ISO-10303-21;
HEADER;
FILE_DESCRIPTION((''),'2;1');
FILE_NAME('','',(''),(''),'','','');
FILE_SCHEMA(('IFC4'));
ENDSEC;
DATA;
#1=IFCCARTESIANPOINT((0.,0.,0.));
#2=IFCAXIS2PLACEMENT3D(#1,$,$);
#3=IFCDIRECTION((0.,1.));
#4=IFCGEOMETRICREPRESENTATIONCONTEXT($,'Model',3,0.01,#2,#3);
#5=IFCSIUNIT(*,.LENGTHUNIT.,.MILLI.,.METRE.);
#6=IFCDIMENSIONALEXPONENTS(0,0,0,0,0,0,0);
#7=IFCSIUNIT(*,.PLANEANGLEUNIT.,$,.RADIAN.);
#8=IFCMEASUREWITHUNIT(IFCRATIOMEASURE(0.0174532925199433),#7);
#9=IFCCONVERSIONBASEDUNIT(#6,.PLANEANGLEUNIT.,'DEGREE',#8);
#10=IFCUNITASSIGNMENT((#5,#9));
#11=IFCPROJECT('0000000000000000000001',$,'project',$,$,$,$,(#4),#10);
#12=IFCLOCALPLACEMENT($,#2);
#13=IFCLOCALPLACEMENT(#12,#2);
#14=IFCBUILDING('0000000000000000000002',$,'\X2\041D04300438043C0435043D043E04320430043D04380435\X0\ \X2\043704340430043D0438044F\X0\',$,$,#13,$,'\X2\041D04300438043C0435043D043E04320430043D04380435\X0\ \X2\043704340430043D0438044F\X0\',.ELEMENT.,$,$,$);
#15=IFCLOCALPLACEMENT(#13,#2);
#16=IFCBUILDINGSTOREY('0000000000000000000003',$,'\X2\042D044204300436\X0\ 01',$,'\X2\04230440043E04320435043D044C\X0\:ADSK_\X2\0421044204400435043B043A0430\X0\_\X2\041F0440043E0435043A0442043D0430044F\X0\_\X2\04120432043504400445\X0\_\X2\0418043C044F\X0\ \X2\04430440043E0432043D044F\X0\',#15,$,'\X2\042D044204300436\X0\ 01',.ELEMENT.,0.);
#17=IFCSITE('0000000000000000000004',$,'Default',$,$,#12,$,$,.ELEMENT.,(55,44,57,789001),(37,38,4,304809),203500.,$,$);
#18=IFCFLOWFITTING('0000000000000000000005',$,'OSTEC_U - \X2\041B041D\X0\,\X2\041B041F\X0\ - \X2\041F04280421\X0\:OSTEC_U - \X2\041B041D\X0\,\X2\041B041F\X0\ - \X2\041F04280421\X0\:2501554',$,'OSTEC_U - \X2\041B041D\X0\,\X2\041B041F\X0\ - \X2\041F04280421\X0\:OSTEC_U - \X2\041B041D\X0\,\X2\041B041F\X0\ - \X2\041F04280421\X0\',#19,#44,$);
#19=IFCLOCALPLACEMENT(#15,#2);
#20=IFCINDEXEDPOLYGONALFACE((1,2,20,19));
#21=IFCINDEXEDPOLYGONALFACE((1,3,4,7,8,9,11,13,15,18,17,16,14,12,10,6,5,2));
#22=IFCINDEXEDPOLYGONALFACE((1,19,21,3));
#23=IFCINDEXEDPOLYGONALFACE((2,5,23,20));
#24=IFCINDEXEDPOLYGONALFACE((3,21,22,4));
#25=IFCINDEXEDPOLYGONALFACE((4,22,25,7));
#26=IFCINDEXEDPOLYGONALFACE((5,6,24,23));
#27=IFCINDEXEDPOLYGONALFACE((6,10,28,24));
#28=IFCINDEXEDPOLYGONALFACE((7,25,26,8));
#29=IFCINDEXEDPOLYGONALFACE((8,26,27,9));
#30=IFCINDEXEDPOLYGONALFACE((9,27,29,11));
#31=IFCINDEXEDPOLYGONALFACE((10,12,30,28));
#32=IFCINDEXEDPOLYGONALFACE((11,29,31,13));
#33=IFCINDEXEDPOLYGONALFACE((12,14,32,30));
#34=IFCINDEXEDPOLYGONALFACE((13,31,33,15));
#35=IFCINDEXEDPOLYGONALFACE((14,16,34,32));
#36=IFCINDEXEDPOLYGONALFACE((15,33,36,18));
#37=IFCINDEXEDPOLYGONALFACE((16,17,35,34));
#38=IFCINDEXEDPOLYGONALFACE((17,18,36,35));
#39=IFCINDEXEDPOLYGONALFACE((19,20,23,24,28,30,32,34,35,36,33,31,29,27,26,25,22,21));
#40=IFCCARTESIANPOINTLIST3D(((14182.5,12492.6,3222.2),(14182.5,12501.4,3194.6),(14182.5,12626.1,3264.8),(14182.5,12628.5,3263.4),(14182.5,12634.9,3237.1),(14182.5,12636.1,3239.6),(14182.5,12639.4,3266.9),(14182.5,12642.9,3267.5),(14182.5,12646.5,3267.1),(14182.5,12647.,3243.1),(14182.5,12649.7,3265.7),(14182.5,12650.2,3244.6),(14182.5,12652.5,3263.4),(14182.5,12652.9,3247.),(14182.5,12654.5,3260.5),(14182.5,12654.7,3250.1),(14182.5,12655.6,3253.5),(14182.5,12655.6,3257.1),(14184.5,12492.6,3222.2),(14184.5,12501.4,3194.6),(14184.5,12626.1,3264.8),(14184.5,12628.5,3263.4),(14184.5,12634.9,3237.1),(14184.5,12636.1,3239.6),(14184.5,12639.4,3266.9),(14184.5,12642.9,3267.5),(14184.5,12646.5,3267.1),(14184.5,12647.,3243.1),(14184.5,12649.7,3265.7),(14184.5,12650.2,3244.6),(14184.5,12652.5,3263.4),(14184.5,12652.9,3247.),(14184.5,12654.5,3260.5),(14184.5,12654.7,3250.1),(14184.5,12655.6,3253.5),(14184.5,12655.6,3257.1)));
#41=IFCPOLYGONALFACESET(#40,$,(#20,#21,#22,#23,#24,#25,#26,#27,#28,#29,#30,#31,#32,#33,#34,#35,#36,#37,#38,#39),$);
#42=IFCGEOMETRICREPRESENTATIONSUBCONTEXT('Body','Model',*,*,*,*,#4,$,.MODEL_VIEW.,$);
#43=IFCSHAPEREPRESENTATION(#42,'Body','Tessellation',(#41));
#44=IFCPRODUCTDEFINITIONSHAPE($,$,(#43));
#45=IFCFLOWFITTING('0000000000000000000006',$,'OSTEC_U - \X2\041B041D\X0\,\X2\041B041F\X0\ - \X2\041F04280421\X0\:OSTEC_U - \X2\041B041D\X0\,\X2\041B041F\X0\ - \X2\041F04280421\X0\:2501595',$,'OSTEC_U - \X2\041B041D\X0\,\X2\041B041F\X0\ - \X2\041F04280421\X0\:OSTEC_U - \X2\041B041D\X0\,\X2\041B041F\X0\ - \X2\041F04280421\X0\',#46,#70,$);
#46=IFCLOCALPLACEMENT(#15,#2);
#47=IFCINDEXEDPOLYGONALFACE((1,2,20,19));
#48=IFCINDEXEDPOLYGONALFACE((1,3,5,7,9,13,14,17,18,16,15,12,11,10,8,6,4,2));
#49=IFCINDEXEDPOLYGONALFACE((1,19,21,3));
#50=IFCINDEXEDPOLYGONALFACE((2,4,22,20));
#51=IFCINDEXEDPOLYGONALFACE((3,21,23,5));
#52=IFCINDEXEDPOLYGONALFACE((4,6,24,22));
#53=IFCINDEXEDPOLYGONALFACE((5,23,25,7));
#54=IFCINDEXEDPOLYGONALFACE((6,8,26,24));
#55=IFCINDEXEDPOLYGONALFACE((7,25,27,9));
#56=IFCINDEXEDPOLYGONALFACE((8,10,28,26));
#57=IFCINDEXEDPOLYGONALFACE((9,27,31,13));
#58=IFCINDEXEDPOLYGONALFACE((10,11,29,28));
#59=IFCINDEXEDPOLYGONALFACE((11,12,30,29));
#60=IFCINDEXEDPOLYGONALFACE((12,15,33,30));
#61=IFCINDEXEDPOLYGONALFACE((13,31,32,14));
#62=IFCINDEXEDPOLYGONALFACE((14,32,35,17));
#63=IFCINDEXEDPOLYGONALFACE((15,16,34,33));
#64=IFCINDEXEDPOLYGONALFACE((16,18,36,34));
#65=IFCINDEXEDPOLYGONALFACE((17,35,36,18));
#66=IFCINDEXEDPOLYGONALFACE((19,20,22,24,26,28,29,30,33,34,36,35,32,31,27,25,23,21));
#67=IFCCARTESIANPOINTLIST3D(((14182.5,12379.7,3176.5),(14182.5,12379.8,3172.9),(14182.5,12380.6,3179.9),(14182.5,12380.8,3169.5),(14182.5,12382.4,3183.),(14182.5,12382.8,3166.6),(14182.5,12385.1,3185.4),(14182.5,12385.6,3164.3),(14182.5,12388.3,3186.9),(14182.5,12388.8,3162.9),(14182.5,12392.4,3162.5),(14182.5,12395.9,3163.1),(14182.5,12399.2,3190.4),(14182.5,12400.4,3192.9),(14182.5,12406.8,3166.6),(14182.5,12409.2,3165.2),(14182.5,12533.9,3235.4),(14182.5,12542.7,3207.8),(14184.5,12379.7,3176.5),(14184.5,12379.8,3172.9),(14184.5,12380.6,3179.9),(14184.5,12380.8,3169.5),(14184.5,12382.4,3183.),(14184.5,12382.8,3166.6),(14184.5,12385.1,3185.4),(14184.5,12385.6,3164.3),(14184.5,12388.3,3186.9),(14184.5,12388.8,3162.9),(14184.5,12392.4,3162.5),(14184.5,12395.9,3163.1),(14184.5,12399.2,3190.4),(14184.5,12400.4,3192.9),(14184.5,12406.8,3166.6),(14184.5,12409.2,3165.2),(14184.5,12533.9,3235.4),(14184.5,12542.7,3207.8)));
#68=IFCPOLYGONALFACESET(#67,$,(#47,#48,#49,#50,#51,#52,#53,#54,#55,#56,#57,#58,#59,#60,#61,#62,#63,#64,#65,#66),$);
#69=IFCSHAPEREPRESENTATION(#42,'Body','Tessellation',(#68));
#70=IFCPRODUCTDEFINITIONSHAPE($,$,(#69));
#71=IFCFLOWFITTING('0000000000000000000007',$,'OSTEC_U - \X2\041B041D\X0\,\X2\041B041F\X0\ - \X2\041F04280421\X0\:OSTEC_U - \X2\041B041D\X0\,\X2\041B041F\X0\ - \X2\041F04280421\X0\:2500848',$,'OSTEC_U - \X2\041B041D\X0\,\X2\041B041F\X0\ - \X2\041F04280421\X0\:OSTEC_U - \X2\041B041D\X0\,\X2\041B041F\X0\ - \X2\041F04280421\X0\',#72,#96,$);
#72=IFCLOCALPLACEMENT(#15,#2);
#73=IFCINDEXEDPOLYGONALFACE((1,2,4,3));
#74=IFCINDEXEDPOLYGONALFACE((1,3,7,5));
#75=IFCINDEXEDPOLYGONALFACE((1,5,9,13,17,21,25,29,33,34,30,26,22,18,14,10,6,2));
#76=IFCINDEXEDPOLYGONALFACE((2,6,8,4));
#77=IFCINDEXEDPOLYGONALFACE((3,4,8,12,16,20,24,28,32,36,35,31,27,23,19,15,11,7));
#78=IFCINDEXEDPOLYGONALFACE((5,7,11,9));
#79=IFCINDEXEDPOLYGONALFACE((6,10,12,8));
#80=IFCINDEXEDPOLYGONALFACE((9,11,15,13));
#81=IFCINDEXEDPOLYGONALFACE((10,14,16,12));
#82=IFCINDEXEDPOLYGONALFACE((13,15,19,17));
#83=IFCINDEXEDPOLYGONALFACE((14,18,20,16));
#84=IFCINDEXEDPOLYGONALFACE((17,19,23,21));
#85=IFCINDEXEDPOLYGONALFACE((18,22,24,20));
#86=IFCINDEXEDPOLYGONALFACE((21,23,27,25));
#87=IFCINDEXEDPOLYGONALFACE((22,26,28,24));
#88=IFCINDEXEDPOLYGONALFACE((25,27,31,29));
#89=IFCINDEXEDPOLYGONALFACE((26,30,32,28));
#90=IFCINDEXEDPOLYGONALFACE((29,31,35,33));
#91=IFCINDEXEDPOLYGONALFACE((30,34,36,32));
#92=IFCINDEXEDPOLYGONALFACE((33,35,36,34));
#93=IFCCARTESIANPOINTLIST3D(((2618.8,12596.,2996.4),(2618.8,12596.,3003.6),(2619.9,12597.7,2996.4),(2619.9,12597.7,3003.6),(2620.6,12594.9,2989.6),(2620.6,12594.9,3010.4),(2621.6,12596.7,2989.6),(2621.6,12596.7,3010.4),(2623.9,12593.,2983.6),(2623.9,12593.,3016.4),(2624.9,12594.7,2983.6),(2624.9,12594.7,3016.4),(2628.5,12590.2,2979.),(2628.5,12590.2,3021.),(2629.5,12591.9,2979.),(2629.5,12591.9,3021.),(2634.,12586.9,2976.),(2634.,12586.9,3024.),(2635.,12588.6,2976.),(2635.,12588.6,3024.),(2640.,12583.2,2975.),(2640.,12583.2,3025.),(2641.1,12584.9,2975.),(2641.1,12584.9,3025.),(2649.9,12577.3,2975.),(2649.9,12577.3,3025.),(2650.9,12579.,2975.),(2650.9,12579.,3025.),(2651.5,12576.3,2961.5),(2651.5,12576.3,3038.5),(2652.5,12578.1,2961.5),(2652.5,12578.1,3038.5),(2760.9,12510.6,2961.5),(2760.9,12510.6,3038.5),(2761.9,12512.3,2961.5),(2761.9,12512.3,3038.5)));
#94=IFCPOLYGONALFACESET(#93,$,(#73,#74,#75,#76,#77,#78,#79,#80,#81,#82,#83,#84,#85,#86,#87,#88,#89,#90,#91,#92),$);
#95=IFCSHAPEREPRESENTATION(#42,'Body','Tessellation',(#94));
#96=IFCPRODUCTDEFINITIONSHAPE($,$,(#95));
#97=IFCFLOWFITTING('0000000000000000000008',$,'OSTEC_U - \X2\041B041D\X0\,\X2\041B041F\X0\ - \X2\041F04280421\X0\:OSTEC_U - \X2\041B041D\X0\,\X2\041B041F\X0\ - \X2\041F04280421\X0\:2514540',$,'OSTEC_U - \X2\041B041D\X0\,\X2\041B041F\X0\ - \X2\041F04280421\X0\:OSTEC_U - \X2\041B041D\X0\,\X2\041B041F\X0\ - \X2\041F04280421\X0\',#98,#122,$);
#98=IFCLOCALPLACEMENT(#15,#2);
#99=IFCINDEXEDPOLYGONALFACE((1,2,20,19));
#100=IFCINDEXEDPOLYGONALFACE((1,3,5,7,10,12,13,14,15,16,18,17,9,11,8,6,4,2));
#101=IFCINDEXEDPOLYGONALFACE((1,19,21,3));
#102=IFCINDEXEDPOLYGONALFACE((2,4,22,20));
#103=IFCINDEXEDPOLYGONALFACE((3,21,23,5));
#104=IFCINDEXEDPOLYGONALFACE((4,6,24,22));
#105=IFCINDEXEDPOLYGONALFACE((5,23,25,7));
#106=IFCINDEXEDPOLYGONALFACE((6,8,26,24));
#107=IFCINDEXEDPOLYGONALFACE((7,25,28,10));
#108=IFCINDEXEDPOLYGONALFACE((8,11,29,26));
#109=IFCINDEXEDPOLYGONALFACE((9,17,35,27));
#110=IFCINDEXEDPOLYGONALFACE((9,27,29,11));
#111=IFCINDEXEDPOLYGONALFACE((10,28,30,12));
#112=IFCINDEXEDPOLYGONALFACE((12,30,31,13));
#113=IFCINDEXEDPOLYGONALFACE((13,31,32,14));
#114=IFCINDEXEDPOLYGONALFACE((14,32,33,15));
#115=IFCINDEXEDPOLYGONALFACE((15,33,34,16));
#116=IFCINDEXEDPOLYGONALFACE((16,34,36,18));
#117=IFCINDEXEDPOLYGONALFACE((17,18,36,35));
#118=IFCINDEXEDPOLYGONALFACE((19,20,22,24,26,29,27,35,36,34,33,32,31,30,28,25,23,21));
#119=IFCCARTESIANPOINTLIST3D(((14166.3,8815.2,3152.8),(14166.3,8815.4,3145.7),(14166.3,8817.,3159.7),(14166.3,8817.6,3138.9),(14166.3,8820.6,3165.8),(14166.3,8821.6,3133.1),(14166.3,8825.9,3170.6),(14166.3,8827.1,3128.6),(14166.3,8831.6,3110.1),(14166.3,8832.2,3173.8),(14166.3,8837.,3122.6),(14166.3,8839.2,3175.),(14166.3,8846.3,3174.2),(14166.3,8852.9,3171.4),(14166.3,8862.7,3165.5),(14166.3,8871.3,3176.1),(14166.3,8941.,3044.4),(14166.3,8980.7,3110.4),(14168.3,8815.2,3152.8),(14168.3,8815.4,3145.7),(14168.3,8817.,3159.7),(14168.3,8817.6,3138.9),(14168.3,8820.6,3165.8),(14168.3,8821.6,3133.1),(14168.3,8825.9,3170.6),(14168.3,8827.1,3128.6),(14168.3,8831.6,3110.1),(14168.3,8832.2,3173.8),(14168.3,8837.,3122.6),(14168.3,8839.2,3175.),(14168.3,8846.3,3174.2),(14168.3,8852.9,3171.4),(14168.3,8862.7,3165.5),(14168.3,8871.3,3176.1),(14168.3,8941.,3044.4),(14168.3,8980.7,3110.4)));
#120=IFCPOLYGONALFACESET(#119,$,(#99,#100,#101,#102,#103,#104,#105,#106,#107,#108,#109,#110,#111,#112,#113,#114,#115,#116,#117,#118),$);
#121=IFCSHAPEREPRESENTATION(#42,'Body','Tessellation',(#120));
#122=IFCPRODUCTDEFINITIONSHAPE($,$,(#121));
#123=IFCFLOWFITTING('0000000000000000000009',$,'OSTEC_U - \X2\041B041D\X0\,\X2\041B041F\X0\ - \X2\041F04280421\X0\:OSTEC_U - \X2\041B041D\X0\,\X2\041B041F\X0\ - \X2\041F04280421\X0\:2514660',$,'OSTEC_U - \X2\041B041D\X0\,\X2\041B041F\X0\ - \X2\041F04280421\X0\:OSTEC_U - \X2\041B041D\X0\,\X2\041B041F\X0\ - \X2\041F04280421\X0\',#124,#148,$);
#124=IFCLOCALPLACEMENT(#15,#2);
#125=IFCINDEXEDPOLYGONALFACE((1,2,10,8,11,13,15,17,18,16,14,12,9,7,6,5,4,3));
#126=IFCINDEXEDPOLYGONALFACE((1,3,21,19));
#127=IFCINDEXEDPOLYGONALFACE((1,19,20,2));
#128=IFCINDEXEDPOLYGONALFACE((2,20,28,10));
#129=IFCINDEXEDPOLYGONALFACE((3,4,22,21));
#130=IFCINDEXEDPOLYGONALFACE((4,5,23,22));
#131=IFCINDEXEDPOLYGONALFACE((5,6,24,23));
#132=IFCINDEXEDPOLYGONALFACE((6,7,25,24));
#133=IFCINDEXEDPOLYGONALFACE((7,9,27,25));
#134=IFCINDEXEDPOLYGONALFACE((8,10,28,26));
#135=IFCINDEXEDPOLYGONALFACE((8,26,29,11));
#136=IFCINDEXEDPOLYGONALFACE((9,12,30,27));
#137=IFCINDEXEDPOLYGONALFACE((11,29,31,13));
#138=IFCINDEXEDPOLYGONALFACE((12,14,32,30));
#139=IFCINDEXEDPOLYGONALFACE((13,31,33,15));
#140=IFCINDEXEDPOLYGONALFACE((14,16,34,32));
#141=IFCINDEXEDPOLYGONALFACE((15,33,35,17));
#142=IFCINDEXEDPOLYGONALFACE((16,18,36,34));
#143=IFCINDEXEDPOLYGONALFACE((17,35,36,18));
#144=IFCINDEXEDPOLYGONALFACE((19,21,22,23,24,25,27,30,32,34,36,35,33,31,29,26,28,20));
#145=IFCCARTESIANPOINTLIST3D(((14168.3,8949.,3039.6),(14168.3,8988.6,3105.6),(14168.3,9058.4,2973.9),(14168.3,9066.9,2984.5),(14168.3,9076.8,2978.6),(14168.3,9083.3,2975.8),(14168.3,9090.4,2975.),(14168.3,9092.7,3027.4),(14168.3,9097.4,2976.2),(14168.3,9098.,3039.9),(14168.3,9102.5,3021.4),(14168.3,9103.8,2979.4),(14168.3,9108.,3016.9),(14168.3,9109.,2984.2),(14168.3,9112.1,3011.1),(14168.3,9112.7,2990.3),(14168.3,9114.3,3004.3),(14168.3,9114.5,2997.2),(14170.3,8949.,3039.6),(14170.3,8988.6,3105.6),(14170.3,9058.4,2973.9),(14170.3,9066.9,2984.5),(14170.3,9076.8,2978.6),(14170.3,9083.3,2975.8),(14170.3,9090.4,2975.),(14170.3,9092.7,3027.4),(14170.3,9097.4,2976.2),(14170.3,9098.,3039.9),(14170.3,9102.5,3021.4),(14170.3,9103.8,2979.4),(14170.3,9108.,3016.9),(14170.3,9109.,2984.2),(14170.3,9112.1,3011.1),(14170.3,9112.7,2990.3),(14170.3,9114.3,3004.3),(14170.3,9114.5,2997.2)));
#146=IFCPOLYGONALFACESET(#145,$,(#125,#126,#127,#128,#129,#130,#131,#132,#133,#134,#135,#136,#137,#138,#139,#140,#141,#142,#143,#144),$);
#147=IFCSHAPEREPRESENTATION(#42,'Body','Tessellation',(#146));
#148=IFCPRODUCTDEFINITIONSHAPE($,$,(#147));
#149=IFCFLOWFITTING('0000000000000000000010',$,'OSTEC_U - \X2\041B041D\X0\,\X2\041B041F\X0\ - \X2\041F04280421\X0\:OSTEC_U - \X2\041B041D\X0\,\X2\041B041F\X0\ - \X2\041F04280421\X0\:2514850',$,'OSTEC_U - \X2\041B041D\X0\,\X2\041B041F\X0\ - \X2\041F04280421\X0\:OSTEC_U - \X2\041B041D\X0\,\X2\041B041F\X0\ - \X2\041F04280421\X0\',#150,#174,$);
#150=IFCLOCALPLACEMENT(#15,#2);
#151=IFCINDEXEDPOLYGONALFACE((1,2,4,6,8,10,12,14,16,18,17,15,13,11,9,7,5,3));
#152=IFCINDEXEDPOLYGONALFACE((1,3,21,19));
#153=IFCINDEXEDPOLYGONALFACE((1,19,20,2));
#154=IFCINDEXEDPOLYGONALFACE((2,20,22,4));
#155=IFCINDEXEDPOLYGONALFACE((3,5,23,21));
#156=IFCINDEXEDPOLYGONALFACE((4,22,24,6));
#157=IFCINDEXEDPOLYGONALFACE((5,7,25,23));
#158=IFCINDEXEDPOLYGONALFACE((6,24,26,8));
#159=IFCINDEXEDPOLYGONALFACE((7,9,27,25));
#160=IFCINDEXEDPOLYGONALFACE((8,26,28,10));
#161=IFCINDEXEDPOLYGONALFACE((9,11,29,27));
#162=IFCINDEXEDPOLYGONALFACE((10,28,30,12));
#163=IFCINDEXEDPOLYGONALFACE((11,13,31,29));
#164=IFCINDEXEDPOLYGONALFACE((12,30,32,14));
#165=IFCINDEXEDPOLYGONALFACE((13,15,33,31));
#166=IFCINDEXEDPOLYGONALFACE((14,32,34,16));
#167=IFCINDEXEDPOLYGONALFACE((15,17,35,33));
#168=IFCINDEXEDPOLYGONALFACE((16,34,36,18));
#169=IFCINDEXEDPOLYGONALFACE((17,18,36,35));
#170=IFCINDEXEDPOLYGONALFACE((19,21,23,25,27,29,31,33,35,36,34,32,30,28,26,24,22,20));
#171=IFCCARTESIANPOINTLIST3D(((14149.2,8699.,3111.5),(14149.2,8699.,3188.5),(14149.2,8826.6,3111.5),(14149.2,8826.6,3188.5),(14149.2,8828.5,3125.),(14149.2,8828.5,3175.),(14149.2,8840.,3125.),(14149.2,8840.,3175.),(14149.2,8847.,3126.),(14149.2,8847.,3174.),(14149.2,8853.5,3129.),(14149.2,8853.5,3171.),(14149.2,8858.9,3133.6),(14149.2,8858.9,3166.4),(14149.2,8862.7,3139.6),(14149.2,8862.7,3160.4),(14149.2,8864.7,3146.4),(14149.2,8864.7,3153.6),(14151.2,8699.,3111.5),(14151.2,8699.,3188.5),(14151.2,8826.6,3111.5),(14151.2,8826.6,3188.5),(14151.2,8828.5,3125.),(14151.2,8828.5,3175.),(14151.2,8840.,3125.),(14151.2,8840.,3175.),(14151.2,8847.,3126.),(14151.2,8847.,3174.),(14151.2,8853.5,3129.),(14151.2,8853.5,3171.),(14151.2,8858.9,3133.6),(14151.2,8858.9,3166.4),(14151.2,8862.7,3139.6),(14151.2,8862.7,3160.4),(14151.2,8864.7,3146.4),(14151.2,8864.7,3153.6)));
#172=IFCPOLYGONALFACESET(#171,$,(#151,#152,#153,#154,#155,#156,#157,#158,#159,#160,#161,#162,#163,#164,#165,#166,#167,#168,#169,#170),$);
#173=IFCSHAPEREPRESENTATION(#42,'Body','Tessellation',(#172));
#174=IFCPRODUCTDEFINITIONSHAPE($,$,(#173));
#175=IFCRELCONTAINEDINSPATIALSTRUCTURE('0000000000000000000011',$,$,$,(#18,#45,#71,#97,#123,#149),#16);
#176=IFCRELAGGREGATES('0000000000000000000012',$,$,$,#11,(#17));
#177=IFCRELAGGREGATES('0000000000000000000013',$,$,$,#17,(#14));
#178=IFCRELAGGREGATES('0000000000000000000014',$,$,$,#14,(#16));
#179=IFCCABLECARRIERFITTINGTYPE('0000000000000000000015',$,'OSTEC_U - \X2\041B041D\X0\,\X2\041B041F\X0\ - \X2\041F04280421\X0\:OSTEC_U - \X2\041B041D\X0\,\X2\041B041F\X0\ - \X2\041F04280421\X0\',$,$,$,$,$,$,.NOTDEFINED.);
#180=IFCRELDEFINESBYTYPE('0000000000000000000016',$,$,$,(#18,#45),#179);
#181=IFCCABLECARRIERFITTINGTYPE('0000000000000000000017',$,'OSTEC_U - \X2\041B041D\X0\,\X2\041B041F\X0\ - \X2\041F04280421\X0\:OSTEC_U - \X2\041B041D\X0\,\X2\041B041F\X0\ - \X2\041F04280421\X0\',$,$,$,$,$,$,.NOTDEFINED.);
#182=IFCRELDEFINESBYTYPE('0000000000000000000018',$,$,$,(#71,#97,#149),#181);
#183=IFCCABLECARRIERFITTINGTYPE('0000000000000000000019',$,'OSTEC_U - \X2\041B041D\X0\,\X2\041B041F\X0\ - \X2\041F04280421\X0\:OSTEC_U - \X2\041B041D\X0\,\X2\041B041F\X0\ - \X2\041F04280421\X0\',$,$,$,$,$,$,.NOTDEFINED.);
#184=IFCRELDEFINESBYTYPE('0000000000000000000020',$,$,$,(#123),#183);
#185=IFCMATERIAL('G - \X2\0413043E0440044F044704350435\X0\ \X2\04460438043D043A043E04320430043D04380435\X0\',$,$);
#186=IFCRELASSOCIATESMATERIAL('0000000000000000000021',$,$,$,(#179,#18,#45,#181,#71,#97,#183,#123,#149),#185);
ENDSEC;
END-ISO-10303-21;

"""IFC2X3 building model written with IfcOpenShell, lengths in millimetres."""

from ifc_helpers import new_model, entity, si_unit, converted_unit, direction, frame, frame_2d, origin, place, context, subcontext, project, spatial, polyline, circle_curve, parameter, trimmed, segment, composite_curve, outline, extrude, source, transform, mapped, material, type_object, type_shapes, element, save


model = new_model("IFC2X3")

# Units and contexts
model_context = context("Model", 3, precision=0.01, world=origin(), true_north=direction((0.0, 1.0)))
body_context = subcontext(model_context, "Body", "Model", "MODEL_VIEW")
ifc_project = project(units=[si_unit("LENGTHUNIT", "METRE", prefix="MILLI"), converted_unit("PLANEANGLEUNIT", "DEGREE", entity("IfcRatioMeasure", 0.0174532925199433), si_unit("PLANEANGLEUNIT", "RADIAN"), dimensions=[0, 0, 0, 0, 0, 0, 0])], contexts=[model_context])

# Site, building, storey
site_placement = place(None, origin())
site = spatial("IfcSite", under=ifc_project, at=site_placement, Name="Default", CompositionType="ELEMENT", RefLatitude=(55, 44, 57, 789001), RefLongitude=(37, 38, 4, 304809), RefElevation=203500.0)
building_placement = place(site_placement, origin())
building = spatial("IfcBuilding", under=site, at=building_placement, Name="Наименование здания", LongName="Наименование здания", CompositionType="ELEMENT")
storey_placement = place(building_placement, origin())
storey = spatial("IfcBuildingStorey", under=building, at=storey_placement, Name="Этаж 01", ObjectType="Уровень:ADSK_Стрелка_Проектная_Вверх_Имя уровня", LongName="Этаж 01", CompositionType="ELEMENT", Elevation=0.0)

# Flow fittings
ifc_material_1 = material(Name="G - Горячее цинкование")
cable_carrier_fitting_type_1 = type_object("IfcCableCarrierFittingType", Name="OSTEC_U - ЛН,ЛП - ПШС:OSTEC_U - ЛН,ЛП - ПШС", PredefinedType="NOTDEFINED", material=ifc_material_1)
shared_shape_1 = source(origin(), body_context, "Body", "SweptSolid", [
    extrude(outline(composite_curve([segment(trimmed(circle_curve(frame_2d((-44.6, 0.0), x_axis=(1.0, 0.0)), 12.5), [parameter(90.0)], [parameter(270.0)], True, "PARAMETER"), True, "CONTINUOUS"), segment(polyline([(-44.6, -12.5), (-33.1, -12.5)]), True, "CONTINUOUS"), segment(polyline([(-33.1, -12.5), (-31.2, -14.5)]), True, "CONTINUOUS"), segment(polyline([(-31.2, -14.5), (108.9, -14.5)]), True, "CONTINUOUS"), segment(polyline([(108.9, -14.5), (108.9, 14.5)]), True, "CONTINUOUS"), segment(polyline([(108.9, 14.5), (-31.2, 14.5)]), True, "CONTINUOUS"), segment(polyline([(-31.2, 14.5), (-33.1, 12.5)]), True, "CONTINUOUS"), segment(polyline([(-33.1, 12.5), (-44.6, 12.5)]), True, "CONTINUOUS")], self_intersect=False)), frame((44.6, 0.0, 0.0)), (0.0, 0.0, 1.0), 2.0),
])
type_shapes(cable_carrier_fitting_type_1, [shared_shape_1])
for number, where, z_axis, x_axis, name in (
    (1, (14184.5, 12643.2, 3255.0), (-1.0, 0.0, 0.0), (0.0, -0.952827, -0.303512), "OSTEC_U - ЛН,ЛП - ПШС:OSTEC_U - ЛН,ЛП - ПШС:2501554"),
    (2, (14184.5, 12392.1, 3175.0), (-1.0, 0.0, 0.0), (0.0, 0.952827, 0.303512), "OSTEC_U - ЛН,ЛП - ПШС:OSTEC_U - ЛН,ЛП - ПШС:2501595"),
):
    element("IfcFlowFitting", number, at=place(storey_placement, frame(where, z_axis=z_axis, x_axis=x_axis)), inside=storey, type_object=cable_carrier_fitting_type_1, material=ifc_material_1, Name=name, ObjectType="OSTEC_U - ЛН,ЛП - ПШС:OSTEC_U - ЛН,ЛП - ПШС", context=body_context, shape_type="MappedRepresentation", body=[
        mapped(shared_shape_1, transform((0.0, 0.0, 0.0), scale=1.0)),
    ])
cable_carrier_fitting_type_2 = type_object("IfcCableCarrierFittingType", Name="OSTEC_U - ЛН,ЛП - ПШС:OSTEC_U - ЛН,ЛП - ПШС", PredefinedType="NOTDEFINED", material=ifc_material_1)
shared_shape_2 = source(origin(), body_context, "Body", "SweptSolid", [
    extrude(outline(composite_curve([segment(trimmed(circle_curve(frame_2d((-41.5, 0.0), x_axis=(1.0, 0.0)), 25.0), [parameter(90.0)], [parameter(270.0)], True, "PARAMETER"), True, "CONTINUOUS"), segment(polyline([(-41.5, -25.0), (-30.0, -25.0)]), True, "CONTINUOUS"), segment(polyline([(-30.0, -25.0), (-28.1, -38.5)]), True, "CONTINUOUS"), segment(polyline([(-28.1, -38.5), (99.5, -38.5)]), True, "CONTINUOUS"), segment(polyline([(99.5, -38.5), (99.5, 38.5)]), True, "CONTINUOUS"), segment(polyline([(99.5, 38.5), (-28.1, 38.5)]), True, "CONTINUOUS"), segment(polyline([(-28.1, 38.5), (-30.0, 25.0)]), True, "CONTINUOUS"), segment(polyline([(-30.0, 25.0), (-41.5, 25.0)]), True, "CONTINUOUS")], self_intersect=False)), frame((41.5, 0.0, 0.0), z_axis=(0.0, 0.0, -1.0), x_axis=(1.0, 0.0, 0.0)), (0.0, 0.0, -1.0), 2.0),
])
type_shapes(cable_carrier_fitting_type_2, [shared_shape_2])
for number, where, z_axis, x_axis, name in (
    (3, (2640.1, 12583.2, 3000.0), (0.515038, 0.857167, 0.0), (0.857167, -0.515038, 0.0), "OSTEC_U - ЛН,ЛП - ПШС:OSTEC_U - ЛН,ЛП - ПШС:2500848"),
    (4, (14168.3, 8840.0, 3150.0), (-1.0, 0.0, 0.0), (0.0, 0.857167, -0.515038), "OSTEC_U - ЛН,ЛП - ПШС:OSTEC_U - ЛН,ЛП - ПШС:2514540"),
):
    element("IfcFlowFitting", number, at=place(storey_placement, frame(where, z_axis=z_axis, x_axis=x_axis)), inside=storey, type_object=cable_carrier_fitting_type_2, material=ifc_material_1, Name=name, ObjectType="OSTEC_U - ЛН,ЛП - ПШС:OSTEC_U - ЛН,ЛП - ПШС", context=body_context, shape_type="MappedRepresentation", body=[
        mapped(shared_shape_2, transform((0.0, 0.0, 0.0), scale=1.0)),
    ])
cable_carrier_fitting_type_3 = type_object("IfcCableCarrierFittingType", Name="OSTEC_U - ЛН,ЛП - ПШС:OSTEC_U - ЛН,ЛП - ПШС", PredefinedType="NOTDEFINED", material=ifc_material_1)
type_shapes(cable_carrier_fitting_type_3, [shared_shape_2])
flow_fitting_1_placement = place(storey_placement, frame((14170.3, 9089.6, 3000.0), z_axis=(-1.0, 0.0, 0.0), x_axis=(0.0, -0.857167, 0.515038)))
element("IfcFlowFitting", 5, at=flow_fitting_1_placement, inside=storey, type_object=cable_carrier_fitting_type_3, material=ifc_material_1, Name="OSTEC_U - ЛН,ЛП - ПШС:OSTEC_U - ЛН,ЛП - ПШС:2514660", ObjectType="OSTEC_U - ЛН,ЛП - ПШС:OSTEC_U - ЛН,ЛП - ПШС", context=body_context, shape_type="MappedRepresentation", body=[
    mapped(shared_shape_2, transform((0.0, 0.0, 0.0), scale=1.0)),
])
flow_fitting_2_placement = place(storey_placement, frame((14149.2, 8840.0, 3150.0), z_axis=(1.0, 0.0, 0.0), x_axis=(0.0, -1.0, 0.0)))
element("IfcFlowFitting", 6, at=flow_fitting_2_placement, inside=storey, type_object=cable_carrier_fitting_type_2, material=ifc_material_1, Name="OSTEC_U - ЛН,ЛП - ПШС:OSTEC_U - ЛН,ЛП - ПШС:2514850", ObjectType="OSTEC_U - ЛН,ЛП - ПШС:OSTEC_U - ЛН,ЛП - ПШС", context=body_context, shape_type="MappedRepresentation", body=[
    mapped(shared_shape_2, transform((0.0, 0.0, 0.0), scale=1.0)),
])

save(model, "model.ifc")
